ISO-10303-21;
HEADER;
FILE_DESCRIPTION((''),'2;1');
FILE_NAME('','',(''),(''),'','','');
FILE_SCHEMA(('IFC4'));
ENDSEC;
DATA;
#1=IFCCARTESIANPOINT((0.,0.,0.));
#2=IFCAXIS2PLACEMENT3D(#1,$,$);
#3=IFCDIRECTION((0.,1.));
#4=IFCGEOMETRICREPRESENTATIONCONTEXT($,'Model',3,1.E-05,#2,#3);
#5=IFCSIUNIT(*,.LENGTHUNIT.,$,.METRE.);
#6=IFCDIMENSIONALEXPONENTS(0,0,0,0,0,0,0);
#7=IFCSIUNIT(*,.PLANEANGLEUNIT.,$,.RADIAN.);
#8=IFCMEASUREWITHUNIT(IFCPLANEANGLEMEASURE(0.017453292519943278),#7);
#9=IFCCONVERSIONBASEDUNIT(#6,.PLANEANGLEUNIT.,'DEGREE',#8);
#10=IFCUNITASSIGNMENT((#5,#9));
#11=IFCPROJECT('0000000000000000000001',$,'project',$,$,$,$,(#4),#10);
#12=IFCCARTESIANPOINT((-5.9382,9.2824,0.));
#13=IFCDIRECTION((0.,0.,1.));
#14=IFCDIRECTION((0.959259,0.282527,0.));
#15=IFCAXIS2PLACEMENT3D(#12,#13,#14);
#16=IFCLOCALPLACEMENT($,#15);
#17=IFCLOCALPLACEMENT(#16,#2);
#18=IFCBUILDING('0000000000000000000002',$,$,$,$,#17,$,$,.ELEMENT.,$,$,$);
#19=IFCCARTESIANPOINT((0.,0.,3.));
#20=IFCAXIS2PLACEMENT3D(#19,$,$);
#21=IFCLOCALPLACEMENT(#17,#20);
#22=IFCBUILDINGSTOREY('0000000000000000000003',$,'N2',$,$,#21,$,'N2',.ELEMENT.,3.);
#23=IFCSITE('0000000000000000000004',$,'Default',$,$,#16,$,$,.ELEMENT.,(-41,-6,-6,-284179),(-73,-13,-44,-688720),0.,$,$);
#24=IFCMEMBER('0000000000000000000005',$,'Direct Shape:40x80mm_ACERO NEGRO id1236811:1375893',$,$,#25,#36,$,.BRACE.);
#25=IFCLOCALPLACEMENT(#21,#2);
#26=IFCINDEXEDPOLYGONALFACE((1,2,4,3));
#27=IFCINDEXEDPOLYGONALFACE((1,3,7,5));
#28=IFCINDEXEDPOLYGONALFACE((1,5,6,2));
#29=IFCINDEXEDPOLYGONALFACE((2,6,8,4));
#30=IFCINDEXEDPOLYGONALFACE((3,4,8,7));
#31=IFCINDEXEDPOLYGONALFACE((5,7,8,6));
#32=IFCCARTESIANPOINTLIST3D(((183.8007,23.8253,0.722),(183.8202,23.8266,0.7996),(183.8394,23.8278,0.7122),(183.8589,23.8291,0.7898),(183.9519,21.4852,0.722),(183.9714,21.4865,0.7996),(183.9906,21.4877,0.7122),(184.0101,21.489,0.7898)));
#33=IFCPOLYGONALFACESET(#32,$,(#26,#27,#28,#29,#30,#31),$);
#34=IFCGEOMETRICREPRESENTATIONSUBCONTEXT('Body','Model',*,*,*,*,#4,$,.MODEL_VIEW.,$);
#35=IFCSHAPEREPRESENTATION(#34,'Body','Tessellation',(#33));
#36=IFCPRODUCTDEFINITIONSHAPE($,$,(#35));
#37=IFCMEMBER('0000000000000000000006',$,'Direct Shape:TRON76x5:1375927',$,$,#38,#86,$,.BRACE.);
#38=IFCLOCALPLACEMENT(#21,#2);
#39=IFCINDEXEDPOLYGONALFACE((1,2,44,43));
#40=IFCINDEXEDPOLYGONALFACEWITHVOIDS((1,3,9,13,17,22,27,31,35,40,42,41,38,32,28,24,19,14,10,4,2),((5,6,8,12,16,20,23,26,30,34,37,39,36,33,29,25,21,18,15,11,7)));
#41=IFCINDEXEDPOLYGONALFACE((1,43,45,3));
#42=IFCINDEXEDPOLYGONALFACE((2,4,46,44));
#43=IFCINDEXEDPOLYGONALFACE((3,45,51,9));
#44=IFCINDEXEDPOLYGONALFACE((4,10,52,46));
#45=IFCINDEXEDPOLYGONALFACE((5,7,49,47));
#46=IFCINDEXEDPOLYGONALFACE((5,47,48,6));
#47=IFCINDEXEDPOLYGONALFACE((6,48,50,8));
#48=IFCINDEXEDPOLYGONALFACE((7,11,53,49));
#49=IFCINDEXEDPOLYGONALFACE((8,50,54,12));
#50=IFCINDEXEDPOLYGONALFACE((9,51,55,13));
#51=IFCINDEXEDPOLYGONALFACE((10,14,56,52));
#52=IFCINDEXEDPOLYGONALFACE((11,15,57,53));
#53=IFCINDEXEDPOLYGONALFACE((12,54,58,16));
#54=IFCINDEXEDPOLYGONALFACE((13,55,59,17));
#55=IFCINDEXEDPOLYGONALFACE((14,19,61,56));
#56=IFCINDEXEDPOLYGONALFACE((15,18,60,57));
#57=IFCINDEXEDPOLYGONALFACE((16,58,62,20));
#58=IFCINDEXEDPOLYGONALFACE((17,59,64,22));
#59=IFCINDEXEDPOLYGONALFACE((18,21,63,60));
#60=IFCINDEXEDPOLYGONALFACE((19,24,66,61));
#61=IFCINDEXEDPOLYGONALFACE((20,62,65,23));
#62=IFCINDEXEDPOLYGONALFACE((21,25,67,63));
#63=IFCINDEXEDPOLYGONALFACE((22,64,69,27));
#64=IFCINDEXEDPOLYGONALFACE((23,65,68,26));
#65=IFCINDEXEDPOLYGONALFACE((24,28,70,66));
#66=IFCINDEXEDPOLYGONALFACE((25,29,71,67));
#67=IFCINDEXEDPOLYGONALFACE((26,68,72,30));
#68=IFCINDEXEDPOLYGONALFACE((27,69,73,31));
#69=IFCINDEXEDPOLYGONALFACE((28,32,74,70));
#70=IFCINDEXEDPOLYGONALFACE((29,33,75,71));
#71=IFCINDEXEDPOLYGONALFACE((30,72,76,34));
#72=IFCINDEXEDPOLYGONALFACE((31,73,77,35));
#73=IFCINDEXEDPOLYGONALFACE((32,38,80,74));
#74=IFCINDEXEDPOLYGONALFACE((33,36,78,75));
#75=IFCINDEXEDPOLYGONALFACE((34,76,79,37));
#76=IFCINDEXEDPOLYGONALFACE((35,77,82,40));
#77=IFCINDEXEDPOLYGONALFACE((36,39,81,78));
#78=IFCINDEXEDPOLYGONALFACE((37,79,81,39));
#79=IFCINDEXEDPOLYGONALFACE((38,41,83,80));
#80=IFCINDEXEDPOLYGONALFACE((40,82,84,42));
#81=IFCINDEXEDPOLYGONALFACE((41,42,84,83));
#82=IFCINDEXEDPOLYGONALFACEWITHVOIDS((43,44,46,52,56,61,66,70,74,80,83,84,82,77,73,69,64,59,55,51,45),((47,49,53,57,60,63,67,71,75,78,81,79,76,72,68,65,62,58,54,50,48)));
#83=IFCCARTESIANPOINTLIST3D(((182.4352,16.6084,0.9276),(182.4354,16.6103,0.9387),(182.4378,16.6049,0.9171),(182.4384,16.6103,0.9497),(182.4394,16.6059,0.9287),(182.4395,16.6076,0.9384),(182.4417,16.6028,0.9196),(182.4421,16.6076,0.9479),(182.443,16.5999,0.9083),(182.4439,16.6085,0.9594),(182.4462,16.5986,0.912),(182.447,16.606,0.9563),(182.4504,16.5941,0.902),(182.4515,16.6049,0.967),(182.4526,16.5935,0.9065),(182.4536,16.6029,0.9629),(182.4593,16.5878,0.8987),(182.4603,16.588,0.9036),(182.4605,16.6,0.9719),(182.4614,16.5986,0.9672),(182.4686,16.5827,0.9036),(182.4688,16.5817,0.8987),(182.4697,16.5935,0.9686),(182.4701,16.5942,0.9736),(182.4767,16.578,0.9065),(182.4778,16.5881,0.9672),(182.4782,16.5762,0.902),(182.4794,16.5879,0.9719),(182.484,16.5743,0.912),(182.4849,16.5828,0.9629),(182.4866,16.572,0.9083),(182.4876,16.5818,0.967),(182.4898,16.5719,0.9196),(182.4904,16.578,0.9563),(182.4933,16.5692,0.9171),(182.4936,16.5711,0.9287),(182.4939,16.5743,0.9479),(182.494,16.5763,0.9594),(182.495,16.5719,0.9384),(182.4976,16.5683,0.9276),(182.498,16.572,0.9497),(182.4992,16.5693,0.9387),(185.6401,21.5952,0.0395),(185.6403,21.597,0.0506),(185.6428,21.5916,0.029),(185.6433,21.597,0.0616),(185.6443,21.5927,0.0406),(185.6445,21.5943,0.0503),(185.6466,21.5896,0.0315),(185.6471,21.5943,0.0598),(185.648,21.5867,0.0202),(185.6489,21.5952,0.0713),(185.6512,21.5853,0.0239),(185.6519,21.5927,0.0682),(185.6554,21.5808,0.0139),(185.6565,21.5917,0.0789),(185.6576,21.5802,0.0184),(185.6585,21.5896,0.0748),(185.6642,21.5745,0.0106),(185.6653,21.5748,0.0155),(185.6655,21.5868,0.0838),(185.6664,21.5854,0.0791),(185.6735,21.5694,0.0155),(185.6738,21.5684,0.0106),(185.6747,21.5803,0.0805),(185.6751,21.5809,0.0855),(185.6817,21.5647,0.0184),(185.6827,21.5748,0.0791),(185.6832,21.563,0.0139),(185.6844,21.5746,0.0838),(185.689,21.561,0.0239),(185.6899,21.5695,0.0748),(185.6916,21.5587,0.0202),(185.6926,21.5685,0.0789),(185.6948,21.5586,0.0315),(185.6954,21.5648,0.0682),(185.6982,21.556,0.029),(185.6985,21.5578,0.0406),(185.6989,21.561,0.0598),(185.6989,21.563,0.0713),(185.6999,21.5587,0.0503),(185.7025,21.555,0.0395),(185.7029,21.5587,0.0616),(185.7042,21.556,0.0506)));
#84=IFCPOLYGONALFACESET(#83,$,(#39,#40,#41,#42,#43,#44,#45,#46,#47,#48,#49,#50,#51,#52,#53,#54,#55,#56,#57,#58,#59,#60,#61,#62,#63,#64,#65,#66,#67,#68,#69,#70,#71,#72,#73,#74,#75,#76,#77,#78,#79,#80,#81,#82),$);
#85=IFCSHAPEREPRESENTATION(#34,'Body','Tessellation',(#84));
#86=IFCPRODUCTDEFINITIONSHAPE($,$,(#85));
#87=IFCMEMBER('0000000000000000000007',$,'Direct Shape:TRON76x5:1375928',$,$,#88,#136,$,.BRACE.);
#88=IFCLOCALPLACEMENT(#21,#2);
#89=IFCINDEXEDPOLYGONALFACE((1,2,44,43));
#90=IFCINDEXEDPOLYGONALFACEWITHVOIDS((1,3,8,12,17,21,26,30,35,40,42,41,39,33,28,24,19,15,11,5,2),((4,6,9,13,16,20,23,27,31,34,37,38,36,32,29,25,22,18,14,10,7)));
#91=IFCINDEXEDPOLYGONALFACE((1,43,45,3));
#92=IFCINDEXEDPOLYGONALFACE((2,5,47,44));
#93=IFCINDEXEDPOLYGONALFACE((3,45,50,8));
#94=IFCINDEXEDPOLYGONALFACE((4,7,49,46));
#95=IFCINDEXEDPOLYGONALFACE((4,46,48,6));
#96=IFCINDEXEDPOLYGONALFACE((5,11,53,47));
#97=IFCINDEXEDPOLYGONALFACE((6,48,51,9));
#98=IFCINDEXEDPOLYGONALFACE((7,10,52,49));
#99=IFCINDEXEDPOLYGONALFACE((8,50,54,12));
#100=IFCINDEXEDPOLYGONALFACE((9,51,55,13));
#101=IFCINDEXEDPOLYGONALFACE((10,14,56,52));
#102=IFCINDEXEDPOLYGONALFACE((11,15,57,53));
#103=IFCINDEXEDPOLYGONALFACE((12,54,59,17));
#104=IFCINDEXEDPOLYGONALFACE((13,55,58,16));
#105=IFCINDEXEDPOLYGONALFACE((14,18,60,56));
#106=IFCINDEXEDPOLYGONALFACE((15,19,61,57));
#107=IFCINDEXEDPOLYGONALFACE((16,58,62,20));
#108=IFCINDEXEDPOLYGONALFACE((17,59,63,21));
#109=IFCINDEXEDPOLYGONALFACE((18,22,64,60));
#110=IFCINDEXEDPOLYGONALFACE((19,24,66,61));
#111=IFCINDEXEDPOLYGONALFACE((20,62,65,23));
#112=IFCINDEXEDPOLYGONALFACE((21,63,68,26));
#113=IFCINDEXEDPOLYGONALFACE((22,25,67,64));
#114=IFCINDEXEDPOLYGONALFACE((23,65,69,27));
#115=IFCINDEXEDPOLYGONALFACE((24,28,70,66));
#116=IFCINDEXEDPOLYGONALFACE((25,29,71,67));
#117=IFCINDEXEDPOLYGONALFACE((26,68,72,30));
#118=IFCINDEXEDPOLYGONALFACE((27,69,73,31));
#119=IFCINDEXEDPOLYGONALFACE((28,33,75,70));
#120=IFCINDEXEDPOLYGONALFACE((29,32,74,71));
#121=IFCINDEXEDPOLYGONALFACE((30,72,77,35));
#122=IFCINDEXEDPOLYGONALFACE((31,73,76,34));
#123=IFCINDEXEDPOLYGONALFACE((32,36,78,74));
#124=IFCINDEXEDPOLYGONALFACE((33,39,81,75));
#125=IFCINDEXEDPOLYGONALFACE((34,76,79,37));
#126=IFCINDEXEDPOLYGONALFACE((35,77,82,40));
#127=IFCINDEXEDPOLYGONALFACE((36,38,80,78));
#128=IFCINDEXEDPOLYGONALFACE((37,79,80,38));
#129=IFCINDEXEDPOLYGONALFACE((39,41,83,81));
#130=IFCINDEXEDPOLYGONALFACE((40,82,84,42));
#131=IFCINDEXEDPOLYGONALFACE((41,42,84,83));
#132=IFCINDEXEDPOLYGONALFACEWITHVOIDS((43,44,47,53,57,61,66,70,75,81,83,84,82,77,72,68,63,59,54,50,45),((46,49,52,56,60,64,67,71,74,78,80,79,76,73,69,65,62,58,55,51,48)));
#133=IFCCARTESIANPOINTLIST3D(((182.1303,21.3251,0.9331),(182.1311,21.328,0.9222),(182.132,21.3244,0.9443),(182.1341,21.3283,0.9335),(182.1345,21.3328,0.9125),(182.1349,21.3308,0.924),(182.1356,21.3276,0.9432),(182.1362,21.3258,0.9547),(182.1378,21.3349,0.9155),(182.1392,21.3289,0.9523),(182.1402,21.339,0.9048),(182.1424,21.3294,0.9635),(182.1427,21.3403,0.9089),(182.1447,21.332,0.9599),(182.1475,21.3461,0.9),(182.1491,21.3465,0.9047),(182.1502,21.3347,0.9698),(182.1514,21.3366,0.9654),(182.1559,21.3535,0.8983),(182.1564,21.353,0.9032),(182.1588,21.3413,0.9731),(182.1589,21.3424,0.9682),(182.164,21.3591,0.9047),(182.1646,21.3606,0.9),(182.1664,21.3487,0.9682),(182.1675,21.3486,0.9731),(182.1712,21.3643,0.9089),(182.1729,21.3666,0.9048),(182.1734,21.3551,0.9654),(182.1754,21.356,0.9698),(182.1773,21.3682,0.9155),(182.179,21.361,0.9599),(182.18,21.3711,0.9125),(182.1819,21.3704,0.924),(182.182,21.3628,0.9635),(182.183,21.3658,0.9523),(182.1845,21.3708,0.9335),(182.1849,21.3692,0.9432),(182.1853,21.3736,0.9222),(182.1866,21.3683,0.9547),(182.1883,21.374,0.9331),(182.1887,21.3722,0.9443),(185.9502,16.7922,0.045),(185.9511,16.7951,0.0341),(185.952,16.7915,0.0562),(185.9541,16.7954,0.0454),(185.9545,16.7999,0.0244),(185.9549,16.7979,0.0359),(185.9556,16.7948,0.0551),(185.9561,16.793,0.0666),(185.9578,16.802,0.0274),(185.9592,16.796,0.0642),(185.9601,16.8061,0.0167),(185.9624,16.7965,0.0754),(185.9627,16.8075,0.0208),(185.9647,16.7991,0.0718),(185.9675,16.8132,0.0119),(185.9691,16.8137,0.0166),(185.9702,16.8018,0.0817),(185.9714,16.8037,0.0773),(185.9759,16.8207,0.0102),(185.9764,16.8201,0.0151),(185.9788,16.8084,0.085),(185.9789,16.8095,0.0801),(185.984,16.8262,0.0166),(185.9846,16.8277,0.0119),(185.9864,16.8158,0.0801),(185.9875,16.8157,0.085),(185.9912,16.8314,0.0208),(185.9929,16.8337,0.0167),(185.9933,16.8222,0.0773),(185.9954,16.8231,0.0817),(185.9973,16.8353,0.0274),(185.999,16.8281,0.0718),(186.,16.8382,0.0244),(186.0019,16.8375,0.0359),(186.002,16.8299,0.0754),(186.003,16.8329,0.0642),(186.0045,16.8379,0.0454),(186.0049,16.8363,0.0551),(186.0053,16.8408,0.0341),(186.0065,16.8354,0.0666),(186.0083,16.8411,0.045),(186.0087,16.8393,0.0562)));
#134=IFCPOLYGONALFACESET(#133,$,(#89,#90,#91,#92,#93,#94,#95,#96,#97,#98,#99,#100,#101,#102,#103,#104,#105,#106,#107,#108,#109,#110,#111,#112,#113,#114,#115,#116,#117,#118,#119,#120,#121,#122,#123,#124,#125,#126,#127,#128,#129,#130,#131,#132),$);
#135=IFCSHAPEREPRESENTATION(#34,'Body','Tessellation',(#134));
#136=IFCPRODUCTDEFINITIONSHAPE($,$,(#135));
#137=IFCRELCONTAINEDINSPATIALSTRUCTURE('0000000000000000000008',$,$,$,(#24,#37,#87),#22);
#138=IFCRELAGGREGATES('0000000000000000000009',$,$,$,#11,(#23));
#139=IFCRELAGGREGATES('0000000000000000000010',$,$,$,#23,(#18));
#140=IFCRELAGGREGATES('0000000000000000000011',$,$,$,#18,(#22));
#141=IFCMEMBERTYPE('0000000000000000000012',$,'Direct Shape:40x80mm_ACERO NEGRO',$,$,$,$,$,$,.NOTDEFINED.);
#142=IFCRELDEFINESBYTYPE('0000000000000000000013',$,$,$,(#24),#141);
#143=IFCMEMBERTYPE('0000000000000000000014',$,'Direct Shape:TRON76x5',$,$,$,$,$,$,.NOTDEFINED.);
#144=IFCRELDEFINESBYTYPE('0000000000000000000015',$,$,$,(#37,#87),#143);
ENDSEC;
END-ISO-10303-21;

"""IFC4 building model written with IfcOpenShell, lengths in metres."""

from ifc_helpers import new_model, entity, si_unit, converted_unit, direction, frame, frame_2d, origin, origin_2d_with_axis, place, context, subcontext, project, spatial, rectangle, hollow_circle, extrude, type_object, element, save


model = new_model("IFC4")

# Units and contexts
model_context = context("Model", 3, precision=1e-05, world=origin(), true_north=direction((0.0, 1.0)))
body_context = subcontext(model_context, "Body", "Model", "MODEL_VIEW")
ifc_project = project(units=[si_unit("LENGTHUNIT", "METRE"), converted_unit("PLANEANGLEUNIT", "DEGREE", entity("IfcPlaneAngleMeasure", 0.017453292519943278), si_unit("PLANEANGLEUNIT", "RADIAN"), dimensions=[0, 0, 0, 0, 0, 0, 0])], contexts=[model_context])

# Site, building, storey
site_placement = place(None, frame((-5.9382, 9.2824, 0.0), z_axis=(0.0, 0.0, 1.0), x_axis=(0.959259, 0.282527, 0.0)))
site = spatial("IfcSite", under=ifc_project, at=site_placement, Name="Default", CompositionType="ELEMENT", RefLatitude=(-41, -6, -6, -284179), RefLongitude=(-73, -13, -44, -688720), RefElevation=0.0)
building_placement = place(site_placement, origin())
building = spatial("IfcBuilding", under=site, at=building_placement, CompositionType="ELEMENT")
storey_placement = place(building_placement, frame((0.0, 0.0, 3.0)))
storey = spatial("IfcBuildingStorey", under=building, at=storey_placement, Name="N2", LongName="N2", CompositionType="ELEMENT", Elevation=3.0)

# Members
member_type_1 = type_object("IfcMemberType", Name="Direct Shape:40x80mm_ACERO NEGRO", PredefinedType="NOTDEFINED")
member_1_placement = place(storey_placement, origin())
element("IfcMember", 1, at=member_1_placement, inside=storey, type_object=member_type_1, Name="Direct Shape:40x80mm_ACERO NEGRO id1236811:1375893", PredefinedType="BRACE", context=body_context, shape_type="SweptSolid", body=[
    extrude(rectangle(XDim=0.08, YDim=0.04, at=frame_2d((0.0, 0.0), x_axis=(0.0, 1.0))), frame((183.981, 21.4871, 0.7559), z_axis=(-0.064471, 0.99792, 0.0), x_axis=(0.967595, 0.062512, -0.244649)), (0.0, 0.0, 1.0), 2.345),
])
member_type_2 = type_object("IfcMemberType", Name="Direct Shape:TRON76x5", PredefinedType="NOTDEFINED")
member_2_placement = place(storey_placement, origin())
element("IfcMember", 2, at=member_2_placement, inside=storey, type_object=member_type_2, Name="Direct Shape:TRON76x5:1375927", PredefinedType="BRACE", context=body_context, shape_type="SweptSolid", body=[
    extrude(hollow_circle(Radius=0.0381, WallThickness=0.005, at=origin_2d_with_axis()), frame((182.4671, 16.5894, 0.9359), z_axis=(0.534696, 0.831954, -0.148165), x_axis=(0.080108, 0.124642, 0.988963)), (0.0, 0.0, 1.0), 5.994),
])
member_3_placement = place(storey_placement, origin())
element("IfcMember", 3, at=member_3_placement, inside=storey, type_object=member_type_2, Name="Direct Shape:TRON76x5:1375928", PredefinedType="BRACE", context=body_context, shape_type="SweptSolid", body=[
    extrude(hollow_circle(Radius=0.0381, WallThickness=0.005, at=origin_2d_with_axis()), frame((182.1595, 21.3492, 0.9359), z_axis=(0.637302, -0.756236, -0.148165), x_axis=(-0.09548, 0.113298, -0.988963)), (0.0, 0.0, 1.0), 5.994),
])

save(model, "model.ifc")
